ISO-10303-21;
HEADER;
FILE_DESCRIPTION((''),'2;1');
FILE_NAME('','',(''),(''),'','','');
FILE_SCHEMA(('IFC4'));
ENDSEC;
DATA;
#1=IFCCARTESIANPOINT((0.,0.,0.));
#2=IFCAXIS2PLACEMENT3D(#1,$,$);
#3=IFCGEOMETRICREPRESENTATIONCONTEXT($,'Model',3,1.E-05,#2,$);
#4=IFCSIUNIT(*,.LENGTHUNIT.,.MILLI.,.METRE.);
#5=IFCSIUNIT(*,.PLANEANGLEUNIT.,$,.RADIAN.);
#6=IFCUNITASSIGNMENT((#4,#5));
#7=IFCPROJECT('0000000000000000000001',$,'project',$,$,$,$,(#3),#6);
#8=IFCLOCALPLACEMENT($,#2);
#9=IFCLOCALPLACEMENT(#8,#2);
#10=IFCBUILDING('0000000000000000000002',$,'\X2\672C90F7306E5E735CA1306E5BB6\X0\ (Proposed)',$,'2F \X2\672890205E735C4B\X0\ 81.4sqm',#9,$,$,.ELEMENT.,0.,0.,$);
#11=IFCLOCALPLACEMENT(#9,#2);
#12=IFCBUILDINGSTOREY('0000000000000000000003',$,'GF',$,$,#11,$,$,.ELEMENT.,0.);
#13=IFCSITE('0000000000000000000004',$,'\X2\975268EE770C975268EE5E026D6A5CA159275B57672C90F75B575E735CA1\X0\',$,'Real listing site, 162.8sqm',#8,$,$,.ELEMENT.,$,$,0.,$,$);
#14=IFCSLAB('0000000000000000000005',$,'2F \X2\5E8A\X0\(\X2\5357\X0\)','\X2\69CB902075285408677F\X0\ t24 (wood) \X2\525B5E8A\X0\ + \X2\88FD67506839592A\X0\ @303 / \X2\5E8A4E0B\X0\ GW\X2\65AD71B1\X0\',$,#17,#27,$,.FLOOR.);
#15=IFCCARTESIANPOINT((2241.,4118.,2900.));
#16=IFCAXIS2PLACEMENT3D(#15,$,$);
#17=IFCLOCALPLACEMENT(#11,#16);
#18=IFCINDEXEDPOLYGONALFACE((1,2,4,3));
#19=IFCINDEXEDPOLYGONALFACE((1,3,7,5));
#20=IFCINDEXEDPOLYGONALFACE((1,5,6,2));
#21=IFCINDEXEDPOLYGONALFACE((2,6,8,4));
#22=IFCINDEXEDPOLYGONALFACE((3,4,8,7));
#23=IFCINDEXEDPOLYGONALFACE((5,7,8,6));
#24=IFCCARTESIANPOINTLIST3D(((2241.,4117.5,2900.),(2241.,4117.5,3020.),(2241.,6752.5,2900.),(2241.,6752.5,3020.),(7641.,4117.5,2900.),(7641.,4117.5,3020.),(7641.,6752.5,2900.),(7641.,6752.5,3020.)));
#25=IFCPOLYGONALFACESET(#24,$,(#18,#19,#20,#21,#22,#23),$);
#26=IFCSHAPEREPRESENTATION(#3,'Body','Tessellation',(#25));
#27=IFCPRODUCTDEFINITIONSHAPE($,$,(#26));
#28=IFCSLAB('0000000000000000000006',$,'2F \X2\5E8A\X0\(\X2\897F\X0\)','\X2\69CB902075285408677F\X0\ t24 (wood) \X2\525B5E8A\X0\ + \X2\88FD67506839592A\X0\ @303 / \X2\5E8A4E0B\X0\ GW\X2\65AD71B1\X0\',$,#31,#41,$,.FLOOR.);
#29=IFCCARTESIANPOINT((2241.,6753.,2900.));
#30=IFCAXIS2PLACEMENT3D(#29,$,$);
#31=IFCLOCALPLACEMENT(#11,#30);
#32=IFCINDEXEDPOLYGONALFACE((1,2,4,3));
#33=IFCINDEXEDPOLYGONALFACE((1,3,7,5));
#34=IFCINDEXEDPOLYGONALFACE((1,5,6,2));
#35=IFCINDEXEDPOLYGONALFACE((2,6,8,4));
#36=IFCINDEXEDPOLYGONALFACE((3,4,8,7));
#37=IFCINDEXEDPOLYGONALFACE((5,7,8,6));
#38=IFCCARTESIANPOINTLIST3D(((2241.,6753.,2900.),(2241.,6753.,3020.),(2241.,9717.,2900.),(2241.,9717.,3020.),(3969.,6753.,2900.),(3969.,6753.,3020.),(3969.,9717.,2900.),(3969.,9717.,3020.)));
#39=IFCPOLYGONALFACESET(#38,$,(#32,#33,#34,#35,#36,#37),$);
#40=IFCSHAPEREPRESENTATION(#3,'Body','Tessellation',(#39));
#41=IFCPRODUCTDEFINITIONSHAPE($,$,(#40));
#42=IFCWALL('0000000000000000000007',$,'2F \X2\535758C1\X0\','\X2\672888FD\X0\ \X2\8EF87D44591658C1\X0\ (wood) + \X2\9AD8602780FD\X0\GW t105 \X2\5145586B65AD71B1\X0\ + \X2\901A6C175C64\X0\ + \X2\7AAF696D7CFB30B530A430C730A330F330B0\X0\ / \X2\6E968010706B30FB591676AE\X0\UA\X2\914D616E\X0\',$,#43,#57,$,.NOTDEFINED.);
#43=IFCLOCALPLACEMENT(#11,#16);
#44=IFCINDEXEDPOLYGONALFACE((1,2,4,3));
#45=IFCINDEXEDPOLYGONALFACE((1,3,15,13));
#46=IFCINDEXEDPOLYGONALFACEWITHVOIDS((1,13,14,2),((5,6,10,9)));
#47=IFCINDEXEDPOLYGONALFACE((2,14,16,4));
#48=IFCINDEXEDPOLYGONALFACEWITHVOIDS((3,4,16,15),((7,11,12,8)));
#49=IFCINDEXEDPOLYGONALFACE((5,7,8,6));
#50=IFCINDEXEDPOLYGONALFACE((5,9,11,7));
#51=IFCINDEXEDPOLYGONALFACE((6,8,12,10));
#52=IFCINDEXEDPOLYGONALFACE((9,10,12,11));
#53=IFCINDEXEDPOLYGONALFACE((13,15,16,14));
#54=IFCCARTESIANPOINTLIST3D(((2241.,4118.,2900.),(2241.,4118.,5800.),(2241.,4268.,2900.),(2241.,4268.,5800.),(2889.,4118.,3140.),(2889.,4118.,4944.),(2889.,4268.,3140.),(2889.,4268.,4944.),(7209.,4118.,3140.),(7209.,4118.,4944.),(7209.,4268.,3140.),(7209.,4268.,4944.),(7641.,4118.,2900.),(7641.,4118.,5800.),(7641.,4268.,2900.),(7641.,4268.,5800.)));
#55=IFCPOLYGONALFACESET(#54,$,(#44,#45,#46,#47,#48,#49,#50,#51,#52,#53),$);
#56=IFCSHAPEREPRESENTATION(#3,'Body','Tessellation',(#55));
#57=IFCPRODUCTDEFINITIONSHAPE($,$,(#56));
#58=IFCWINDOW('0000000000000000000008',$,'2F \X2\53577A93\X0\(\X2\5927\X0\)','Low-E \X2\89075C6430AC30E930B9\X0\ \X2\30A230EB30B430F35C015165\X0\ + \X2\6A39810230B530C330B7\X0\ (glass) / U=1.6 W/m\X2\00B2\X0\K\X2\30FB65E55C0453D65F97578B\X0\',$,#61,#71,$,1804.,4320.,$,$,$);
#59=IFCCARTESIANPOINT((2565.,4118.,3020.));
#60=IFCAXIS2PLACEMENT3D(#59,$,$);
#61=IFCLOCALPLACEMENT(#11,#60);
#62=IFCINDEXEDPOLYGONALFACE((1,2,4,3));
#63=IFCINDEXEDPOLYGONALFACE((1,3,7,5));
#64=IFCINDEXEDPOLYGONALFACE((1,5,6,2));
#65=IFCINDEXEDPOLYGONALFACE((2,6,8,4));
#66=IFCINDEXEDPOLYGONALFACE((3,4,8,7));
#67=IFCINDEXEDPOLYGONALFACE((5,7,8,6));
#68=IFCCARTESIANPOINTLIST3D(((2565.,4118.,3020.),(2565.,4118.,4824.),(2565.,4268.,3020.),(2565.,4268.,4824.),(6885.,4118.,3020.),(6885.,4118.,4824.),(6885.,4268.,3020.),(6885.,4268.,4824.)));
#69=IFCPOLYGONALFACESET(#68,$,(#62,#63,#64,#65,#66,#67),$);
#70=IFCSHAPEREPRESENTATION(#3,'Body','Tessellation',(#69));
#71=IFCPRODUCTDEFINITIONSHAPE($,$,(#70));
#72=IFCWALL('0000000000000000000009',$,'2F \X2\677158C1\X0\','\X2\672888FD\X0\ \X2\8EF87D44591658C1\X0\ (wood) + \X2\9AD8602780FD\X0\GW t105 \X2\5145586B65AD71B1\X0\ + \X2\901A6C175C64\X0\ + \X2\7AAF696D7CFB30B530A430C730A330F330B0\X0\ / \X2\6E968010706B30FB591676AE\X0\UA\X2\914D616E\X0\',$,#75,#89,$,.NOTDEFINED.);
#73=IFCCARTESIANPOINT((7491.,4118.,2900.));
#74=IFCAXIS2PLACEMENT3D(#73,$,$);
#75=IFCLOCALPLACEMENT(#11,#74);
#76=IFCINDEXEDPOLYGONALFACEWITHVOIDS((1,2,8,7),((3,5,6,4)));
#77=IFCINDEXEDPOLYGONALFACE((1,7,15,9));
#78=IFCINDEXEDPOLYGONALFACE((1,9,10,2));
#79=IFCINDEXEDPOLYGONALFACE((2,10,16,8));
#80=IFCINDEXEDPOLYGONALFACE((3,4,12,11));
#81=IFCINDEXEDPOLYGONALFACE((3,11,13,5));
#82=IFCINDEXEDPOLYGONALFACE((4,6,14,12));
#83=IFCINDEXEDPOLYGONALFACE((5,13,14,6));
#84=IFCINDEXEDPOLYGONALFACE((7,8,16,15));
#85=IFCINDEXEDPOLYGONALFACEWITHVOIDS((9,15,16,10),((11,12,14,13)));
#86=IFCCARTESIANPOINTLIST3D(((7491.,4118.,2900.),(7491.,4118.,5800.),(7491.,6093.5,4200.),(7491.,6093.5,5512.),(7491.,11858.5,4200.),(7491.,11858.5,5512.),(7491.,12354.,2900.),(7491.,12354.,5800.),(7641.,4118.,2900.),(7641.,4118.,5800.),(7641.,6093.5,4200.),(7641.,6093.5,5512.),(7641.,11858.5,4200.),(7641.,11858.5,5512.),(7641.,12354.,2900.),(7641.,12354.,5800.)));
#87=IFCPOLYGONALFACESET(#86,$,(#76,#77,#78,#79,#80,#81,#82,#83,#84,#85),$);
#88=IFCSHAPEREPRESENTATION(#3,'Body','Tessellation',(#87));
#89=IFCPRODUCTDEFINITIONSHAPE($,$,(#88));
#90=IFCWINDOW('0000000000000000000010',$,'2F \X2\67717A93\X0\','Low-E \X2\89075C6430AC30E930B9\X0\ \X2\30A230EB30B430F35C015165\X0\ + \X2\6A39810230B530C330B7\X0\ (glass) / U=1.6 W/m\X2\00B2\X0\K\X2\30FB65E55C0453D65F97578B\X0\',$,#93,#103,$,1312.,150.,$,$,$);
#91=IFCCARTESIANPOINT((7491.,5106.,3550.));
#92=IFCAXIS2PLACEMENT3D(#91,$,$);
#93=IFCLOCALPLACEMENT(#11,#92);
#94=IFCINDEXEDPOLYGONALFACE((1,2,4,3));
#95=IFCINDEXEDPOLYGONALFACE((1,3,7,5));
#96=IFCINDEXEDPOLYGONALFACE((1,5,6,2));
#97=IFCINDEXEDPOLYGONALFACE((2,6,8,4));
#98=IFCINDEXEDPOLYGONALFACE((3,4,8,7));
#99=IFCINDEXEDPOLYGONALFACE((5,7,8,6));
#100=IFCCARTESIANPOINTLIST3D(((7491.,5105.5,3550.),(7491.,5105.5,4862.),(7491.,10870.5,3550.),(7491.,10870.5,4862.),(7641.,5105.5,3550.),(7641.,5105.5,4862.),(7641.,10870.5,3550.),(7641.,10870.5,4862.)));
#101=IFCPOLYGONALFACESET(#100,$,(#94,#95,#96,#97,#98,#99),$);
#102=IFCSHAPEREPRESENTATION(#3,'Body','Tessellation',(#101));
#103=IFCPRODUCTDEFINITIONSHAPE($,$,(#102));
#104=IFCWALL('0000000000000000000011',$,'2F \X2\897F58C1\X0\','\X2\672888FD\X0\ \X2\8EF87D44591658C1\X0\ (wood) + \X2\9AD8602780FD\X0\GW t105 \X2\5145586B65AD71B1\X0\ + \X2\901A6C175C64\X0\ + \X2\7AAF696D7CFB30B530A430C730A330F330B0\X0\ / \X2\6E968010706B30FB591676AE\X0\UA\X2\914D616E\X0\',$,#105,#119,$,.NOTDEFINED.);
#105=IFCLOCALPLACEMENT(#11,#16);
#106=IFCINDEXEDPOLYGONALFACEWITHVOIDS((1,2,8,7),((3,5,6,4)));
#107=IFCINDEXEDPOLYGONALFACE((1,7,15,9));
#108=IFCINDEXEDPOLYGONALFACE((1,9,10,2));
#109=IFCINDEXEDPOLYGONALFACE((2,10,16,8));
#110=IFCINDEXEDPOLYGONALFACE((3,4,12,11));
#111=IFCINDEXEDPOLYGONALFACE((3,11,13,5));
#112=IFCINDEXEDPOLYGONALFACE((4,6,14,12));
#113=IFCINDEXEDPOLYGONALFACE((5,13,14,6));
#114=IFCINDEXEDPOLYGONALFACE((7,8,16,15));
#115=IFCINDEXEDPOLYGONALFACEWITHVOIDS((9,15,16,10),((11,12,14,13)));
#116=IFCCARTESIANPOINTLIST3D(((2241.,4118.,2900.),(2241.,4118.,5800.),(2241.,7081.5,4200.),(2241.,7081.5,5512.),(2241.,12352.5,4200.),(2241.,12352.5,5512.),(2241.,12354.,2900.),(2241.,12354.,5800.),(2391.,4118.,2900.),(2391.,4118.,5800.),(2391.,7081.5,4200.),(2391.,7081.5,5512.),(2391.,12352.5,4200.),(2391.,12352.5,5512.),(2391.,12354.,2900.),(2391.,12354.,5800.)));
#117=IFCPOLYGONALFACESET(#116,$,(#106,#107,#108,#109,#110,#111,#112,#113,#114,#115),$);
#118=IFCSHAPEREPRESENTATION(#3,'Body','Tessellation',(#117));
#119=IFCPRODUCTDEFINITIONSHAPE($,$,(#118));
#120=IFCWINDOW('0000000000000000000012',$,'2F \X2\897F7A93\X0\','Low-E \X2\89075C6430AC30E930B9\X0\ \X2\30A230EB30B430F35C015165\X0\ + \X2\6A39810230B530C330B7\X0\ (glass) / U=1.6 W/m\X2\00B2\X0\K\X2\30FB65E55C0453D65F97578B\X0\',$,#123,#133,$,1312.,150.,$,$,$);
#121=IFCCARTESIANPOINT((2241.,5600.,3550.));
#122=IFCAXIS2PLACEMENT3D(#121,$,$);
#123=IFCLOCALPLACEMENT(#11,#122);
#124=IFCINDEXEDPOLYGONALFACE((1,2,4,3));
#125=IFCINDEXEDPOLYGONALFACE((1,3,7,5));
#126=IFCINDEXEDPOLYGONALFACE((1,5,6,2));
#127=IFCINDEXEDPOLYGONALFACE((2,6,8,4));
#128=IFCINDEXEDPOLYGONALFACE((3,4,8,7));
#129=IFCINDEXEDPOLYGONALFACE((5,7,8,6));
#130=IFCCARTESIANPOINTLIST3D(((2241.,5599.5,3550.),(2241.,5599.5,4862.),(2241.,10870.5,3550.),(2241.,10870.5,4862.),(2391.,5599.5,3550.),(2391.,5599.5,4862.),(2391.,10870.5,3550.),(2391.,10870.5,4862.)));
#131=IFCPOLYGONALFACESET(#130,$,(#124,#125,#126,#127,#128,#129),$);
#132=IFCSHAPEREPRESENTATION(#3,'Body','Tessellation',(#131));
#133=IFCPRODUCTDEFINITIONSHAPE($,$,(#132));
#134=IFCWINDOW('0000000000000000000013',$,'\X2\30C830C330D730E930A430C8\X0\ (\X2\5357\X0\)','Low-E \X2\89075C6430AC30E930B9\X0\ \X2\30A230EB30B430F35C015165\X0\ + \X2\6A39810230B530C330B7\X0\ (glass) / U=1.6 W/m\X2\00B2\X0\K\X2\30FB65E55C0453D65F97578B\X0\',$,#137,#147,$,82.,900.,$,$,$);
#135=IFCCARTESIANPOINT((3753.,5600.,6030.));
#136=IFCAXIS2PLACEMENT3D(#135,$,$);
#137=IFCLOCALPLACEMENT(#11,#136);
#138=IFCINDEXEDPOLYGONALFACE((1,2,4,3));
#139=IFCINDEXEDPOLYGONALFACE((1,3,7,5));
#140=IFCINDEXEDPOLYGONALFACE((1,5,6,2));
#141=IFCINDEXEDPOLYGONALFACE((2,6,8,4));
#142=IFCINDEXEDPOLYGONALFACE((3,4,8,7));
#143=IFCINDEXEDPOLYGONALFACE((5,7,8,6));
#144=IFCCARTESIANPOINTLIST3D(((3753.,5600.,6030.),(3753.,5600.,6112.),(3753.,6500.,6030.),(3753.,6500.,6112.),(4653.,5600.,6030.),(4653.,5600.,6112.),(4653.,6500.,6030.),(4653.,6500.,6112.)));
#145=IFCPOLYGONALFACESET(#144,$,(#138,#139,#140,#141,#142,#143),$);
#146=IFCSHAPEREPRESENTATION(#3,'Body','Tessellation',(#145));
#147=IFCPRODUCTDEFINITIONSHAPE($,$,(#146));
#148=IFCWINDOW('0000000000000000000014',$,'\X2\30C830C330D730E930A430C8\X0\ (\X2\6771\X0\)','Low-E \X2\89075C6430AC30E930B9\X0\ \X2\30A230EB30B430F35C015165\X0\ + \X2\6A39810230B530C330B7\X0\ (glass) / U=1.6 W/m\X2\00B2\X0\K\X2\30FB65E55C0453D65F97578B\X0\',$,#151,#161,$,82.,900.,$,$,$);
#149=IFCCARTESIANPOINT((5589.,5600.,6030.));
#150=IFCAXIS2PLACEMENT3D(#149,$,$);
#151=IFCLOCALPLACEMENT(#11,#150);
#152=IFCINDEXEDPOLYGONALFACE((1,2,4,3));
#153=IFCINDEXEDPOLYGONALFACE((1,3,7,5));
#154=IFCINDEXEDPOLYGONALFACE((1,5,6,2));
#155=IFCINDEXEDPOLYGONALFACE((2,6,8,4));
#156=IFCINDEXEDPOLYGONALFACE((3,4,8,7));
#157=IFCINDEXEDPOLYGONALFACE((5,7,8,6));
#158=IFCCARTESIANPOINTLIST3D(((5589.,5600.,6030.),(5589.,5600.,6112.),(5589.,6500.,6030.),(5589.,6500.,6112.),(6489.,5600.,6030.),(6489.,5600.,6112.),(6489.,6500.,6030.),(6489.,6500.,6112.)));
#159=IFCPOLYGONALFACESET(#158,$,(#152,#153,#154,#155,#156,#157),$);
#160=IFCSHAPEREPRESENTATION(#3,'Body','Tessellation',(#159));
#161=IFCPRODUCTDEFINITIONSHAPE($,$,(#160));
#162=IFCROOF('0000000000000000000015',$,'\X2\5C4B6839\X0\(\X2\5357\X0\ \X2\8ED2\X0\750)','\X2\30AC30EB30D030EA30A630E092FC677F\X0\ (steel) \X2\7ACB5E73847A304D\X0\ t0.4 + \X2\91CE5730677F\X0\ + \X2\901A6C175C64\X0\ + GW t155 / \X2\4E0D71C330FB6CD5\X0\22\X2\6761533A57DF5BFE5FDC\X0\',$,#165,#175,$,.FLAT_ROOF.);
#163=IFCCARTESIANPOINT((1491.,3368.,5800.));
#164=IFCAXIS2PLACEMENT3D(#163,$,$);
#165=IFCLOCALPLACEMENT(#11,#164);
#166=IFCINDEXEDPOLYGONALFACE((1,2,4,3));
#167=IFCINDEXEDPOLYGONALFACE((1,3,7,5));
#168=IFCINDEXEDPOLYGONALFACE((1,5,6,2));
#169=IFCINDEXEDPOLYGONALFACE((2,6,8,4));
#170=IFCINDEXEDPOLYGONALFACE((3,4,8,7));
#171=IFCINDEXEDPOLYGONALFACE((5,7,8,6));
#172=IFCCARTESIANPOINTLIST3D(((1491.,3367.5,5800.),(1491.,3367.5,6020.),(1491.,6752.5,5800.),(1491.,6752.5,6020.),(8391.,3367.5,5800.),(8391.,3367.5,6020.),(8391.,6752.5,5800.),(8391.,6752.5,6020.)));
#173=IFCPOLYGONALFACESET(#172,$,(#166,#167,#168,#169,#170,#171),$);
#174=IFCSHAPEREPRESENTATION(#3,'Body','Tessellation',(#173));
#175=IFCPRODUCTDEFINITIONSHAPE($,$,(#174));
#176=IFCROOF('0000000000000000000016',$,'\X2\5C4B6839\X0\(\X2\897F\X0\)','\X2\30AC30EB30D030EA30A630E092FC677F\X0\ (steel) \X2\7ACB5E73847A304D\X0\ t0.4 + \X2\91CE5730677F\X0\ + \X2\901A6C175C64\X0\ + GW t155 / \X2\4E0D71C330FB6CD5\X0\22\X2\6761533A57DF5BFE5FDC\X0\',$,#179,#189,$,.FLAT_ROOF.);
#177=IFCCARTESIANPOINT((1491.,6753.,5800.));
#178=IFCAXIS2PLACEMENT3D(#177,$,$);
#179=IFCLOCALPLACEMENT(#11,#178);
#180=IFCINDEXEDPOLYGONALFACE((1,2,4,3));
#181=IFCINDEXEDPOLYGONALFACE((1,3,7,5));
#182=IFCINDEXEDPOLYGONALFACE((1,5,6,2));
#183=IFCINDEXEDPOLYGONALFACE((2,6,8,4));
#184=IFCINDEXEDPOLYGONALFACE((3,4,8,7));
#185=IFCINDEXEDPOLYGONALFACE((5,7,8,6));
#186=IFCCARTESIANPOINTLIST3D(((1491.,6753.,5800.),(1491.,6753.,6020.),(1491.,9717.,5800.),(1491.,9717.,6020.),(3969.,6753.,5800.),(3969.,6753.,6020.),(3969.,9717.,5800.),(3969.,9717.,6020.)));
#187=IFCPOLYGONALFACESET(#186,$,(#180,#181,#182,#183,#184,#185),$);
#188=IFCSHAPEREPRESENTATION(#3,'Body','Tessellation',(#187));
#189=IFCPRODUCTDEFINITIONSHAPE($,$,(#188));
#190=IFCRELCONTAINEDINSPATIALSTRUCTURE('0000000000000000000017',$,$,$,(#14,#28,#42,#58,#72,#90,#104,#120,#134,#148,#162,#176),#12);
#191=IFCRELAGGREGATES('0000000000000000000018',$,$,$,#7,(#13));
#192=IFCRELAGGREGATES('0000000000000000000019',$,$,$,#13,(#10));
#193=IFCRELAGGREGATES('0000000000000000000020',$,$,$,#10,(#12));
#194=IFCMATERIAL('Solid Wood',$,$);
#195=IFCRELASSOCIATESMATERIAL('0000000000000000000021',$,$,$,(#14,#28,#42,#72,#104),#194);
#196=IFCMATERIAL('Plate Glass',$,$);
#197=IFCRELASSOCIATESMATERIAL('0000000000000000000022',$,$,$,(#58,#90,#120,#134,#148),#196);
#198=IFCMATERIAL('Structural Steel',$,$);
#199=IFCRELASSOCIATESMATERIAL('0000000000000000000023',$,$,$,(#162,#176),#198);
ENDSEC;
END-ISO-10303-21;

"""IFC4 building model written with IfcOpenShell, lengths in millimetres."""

from ifc_helpers import new_model, si_unit, frame, frame_2d, origin, place, context, project, spatial, rectangle, extrude, material, element, fill, save


model = new_model("IFC4")

# Units and contexts
model_context = context("Model", 3, precision=1e-05, world=origin())
ifc_project = project(units=[si_unit("LENGTHUNIT", "METRE", prefix="MILLI"), si_unit("PLANEANGLEUNIT", "RADIAN")], contexts=[model_context])

# Site, building, storey
site_placement = place(None, origin())
site = spatial("IfcSite", under=ifc_project, at=site_placement, Name="青森県青森市浪岡大字本郷字平岡", ObjectType="Real listing site, 162.8sqm", CompositionType="ELEMENT", RefElevation=0.0)
building_placement = place(site_placement, origin())
building = spatial("IfcBuilding", under=site, at=building_placement, Name="本郷の平岡の家 (Proposed)", ObjectType="2F 木造平屋 81.4sqm", CompositionType="ELEMENT", ElevationOfRefHeight=0.0, ElevationOfTerrain=0.0)
storey_placement = place(building_placement, origin())
storey = spatial("IfcBuildingStorey", under=building, at=storey_placement, Name="GF", CompositionType="ELEMENT", Elevation=0.0)

# Slabs
ifc_material_1 = material(Name="Solid Wood")
slab_1_placement = place(storey_placement, frame((2241.0, 4118.0, 2900.0)))
element("IfcSlab", 1, at=slab_1_placement, inside=storey, material=ifc_material_1, Name="2F 床(南)", Description="構造用合板 t24 (wood) 剛床 + 製材根太 @303 / 床下 GW断熱", PredefinedType="FLOOR", context=model_context, shape_type="SweptSolid", body=[
    extrude(rectangle(XDim=5400.0, YDim=2635.0, at=frame_2d((2700.0, 1317.0))), frame((2241.0, 4118.0, 2900.0)), (0.0, 0.0, 1.0), 120.0),
])
slab_2_placement = place(storey_placement, frame((2241.0, 6753.0, 2900.0)))
element("IfcSlab", 2, at=slab_2_placement, inside=storey, material=ifc_material_1, Name="2F 床(西)", Description="構造用合板 t24 (wood) 剛床 + 製材根太 @303 / 床下 GW断熱", PredefinedType="FLOOR", context=model_context, shape_type="SweptSolid", body=[
    extrude(rectangle(XDim=1728.0, YDim=2964.0, at=frame_2d((864.0, 1482.0))), frame((2241.0, 6753.0, 2900.0)), (0.0, 0.0, 1.0), 120.0),
])

# Walls, openings, windows
wall_1_placement = place(storey_placement, frame((2241.0, 4118.0, 2900.0)))
wall_1 = element("IfcWall", 3, at=wall_1_placement, inside=storey, material=ifc_material_1, Name="2F 南壁", Description="木製 軸組外壁 (wood) + 高性能GW t105 充填断熱 + 通気層 + 窯業系サイディング / 準耐火・外皮UA配慮", PredefinedType="NOTDEFINED", context=model_context, shape_type="SweptSolid", body=[
    extrude(rectangle(XDim=5400.0, YDim=150.0, at=frame_2d((2700.0, 75.0))), frame((2241.0, 4118.0, 2900.0)), (0.0, 0.0, 1.0), 2900.0),
])
opening_1_placement = place(storey_placement, frame((2565.0, 4118.0, 3020.0)))
opening_1 = element("IfcOpeningElement", 4, at=opening_1_placement, cuts=wall_1, PredefinedType="NOTDEFINED", context=model_context, shape_type="SweptSolid", body=[
    extrude(rectangle(XDim=4320.0, YDim=150.0, at=frame_2d((2160.0, 75.0))), frame((2565.0, 4118.0, 3020.0)), (0.0, 0.0, 1.0), 1804.0),
])
ifc_material_2 = material(Name="Plate Glass")
window_1_placement = place(storey_placement, frame((2565.0, 4118.0, 3020.0)))
window_1 = element("IfcWindow", 5, at=window_1_placement, inside=storey, material=ifc_material_2, Name="2F 南窓(大)", Description="Low-E 複層ガラス アルゴン封入 + 樹脂サッシ (glass) / U=1.6 W/m²K・日射取得型", OverallHeight=1804.0, OverallWidth=4320.0, context=model_context, shape_type="SweptSolid", body=[
    extrude(rectangle(XDim=4320.0, YDim=150.0, at=frame_2d((2160.0, 75.0))), frame((2565.0, 4118.0, 3020.0)), (0.0, 0.0, 1.0), 1804.0),
])
fill(opening_1, window_1)
wall_2_placement = place(storey_placement, frame((7491.0, 4118.0, 2900.0)))
wall_2 = element("IfcWall", 6, at=wall_2_placement, inside=storey, material=ifc_material_1, Name="2F 東壁", Description="木製 軸組外壁 (wood) + 高性能GW t105 充填断熱 + 通気層 + 窯業系サイディング / 準耐火・外皮UA配慮", PredefinedType="NOTDEFINED", context=model_context, shape_type="SweptSolid", body=[
    extrude(rectangle(XDim=150.0, YDim=8236.0, at=frame_2d((75.0, 4118.0))), frame((7491.0, 4118.0, 2900.0)), (0.0, 0.0, 1.0), 2900.0),
])
opening_2_placement = place(storey_placement, frame((7491.0, 5106.0, 3550.0)))
opening_2 = element("IfcOpeningElement", 7, at=opening_2_placement, cuts=wall_2, PredefinedType="NOTDEFINED", context=model_context, shape_type="SweptSolid", body=[
    extrude(rectangle(XDim=150.0, YDim=5765.0, at=frame_2d((75.0, 2882.0))), frame((7491.0, 5106.0, 3550.0)), (0.0, 0.0, 1.0), 1312.0),
])
window_2_placement = place(storey_placement, frame((7491.0, 5106.0, 3550.0)))
window_2 = element("IfcWindow", 8, at=window_2_placement, inside=storey, material=ifc_material_2, Name="2F 東窓", Description="Low-E 複層ガラス アルゴン封入 + 樹脂サッシ (glass) / U=1.6 W/m²K・日射取得型", OverallHeight=1312.0, OverallWidth=150.0, context=model_context, shape_type="SweptSolid", body=[
    extrude(rectangle(XDim=150.0, YDim=5765.0, at=frame_2d((75.0, 2882.0))), frame((7491.0, 5106.0, 3550.0)), (0.0, 0.0, 1.0), 1312.0),
])
fill(opening_2, window_2)
wall_3_placement = place(storey_placement, frame((2241.0, 4118.0, 2900.0)))
wall_3 = element("IfcWall", 9, at=wall_3_placement, inside=storey, material=ifc_material_1, Name="2F 西壁", Description="木製 軸組外壁 (wood) + 高性能GW t105 充填断熱 + 通気層 + 窯業系サイディング / 準耐火・外皮UA配慮", PredefinedType="NOTDEFINED", context=model_context, shape_type="SweptSolid", body=[
    extrude(rectangle(XDim=150.0, YDim=8236.0, at=frame_2d((75.0, 4118.0))), frame((2241.0, 4118.0, 2900.0)), (0.0, 0.0, 1.0), 2900.0),
])
opening_3_placement = place(storey_placement, frame((2241.0, 5600.0, 3550.0)))
opening_3 = element("IfcOpeningElement", 10, at=opening_3_placement, cuts=wall_3, PredefinedType="NOTDEFINED", context=model_context, shape_type="SweptSolid", body=[
    extrude(rectangle(XDim=150.0, YDim=5271.0, at=frame_2d((75.0, 2635.0))), frame((2241.0, 5600.0, 3550.0)), (0.0, 0.0, 1.0), 1312.0),
])
window_3_placement = place(storey_placement, frame((2241.0, 5600.0, 3550.0)))
window_3 = element("IfcWindow", 11, at=window_3_placement, inside=storey, material=ifc_material_2, Name="2F 西窓", Description="Low-E 複層ガラス アルゴン封入 + 樹脂サッシ (glass) / U=1.6 W/m²K・日射取得型", OverallHeight=1312.0, OverallWidth=150.0, context=model_context, shape_type="SweptSolid", body=[
    extrude(rectangle(XDim=150.0, YDim=5271.0, at=frame_2d((75.0, 2635.0))), frame((2241.0, 5600.0, 3550.0)), (0.0, 0.0, 1.0), 1312.0),
])
fill(opening_3, window_3)

# Windows
window_4_placement = place(storey_placement, frame((3753.0, 5600.0, 6030.0)))
element("IfcWindow", 12, at=window_4_placement, inside=storey, material=ifc_material_2, Name="トップライト (南)", Description="Low-E 複層ガラス アルゴン封入 + 樹脂サッシ (glass) / U=1.6 W/m²K・日射取得型", OverallHeight=82.0, OverallWidth=900.0, context=model_context, shape_type="SweptSolid", body=[
    extrude(rectangle(XDim=900.0, YDim=900.0, at=frame_2d((450.0, 450.0))), frame((3753.0, 5600.0, 6030.0)), (0.0, 0.0, 1.0), 82.0),
])
window_5_placement = place(storey_placement, frame((5589.0, 5600.0, 6030.0)))
element("IfcWindow", 13, at=window_5_placement, inside=storey, material=ifc_material_2, Name="トップライト (東)", Description="Low-E 複層ガラス アルゴン封入 + 樹脂サッシ (glass) / U=1.6 W/m²K・日射取得型", OverallHeight=82.0, OverallWidth=900.0, context=model_context, shape_type="SweptSolid", body=[
    extrude(rectangle(XDim=900.0, YDim=900.0, at=frame_2d((450.0, 450.0))), frame((5589.0, 5600.0, 6030.0)), (0.0, 0.0, 1.0), 82.0),
])

# Roofs
ifc_material_3 = material(Name="Structural Steel")
roof_1_placement = place(storey_placement, frame((1491.0, 3368.0, 5800.0)))
element("IfcRoof", 14, at=roof_1_placement, inside=storey, material=ifc_material_3, Name="屋根(南 軒750)", Description="ガルバリウム鋼板 (steel) 立平葺き t0.4 + 野地板 + 通気層 + GW t155 / 不燃・法22条区域対応", PredefinedType="FLAT_ROOF", context=model_context, shape_type="SweptSolid", body=[
    extrude(rectangle(XDim=6900.0, YDim=3385.0, at=frame_2d((3450.0, 1692.0))), frame((1491.0, 3368.0, 5800.0)), (0.0, 0.0, 1.0), 220.0),
])
roof_2_placement = place(storey_placement, frame((1491.0, 6753.0, 5800.0)))
element("IfcRoof", 15, at=roof_2_placement, inside=storey, material=ifc_material_3, Name="屋根(西)", Description="ガルバリウム鋼板 (steel) 立平葺き t0.4 + 野地板 + 通気層 + GW t155 / 不燃・法22条区域対応", PredefinedType="FLAT_ROOF", context=model_context, shape_type="SweptSolid", body=[
    extrude(rectangle(XDim=2478.0, YDim=2964.0, at=frame_2d((1239.0, 1482.0))), frame((1491.0, 6753.0, 5800.0)), (0.0, 0.0, 1.0), 220.0),
])

save(model, "model.ifc")
